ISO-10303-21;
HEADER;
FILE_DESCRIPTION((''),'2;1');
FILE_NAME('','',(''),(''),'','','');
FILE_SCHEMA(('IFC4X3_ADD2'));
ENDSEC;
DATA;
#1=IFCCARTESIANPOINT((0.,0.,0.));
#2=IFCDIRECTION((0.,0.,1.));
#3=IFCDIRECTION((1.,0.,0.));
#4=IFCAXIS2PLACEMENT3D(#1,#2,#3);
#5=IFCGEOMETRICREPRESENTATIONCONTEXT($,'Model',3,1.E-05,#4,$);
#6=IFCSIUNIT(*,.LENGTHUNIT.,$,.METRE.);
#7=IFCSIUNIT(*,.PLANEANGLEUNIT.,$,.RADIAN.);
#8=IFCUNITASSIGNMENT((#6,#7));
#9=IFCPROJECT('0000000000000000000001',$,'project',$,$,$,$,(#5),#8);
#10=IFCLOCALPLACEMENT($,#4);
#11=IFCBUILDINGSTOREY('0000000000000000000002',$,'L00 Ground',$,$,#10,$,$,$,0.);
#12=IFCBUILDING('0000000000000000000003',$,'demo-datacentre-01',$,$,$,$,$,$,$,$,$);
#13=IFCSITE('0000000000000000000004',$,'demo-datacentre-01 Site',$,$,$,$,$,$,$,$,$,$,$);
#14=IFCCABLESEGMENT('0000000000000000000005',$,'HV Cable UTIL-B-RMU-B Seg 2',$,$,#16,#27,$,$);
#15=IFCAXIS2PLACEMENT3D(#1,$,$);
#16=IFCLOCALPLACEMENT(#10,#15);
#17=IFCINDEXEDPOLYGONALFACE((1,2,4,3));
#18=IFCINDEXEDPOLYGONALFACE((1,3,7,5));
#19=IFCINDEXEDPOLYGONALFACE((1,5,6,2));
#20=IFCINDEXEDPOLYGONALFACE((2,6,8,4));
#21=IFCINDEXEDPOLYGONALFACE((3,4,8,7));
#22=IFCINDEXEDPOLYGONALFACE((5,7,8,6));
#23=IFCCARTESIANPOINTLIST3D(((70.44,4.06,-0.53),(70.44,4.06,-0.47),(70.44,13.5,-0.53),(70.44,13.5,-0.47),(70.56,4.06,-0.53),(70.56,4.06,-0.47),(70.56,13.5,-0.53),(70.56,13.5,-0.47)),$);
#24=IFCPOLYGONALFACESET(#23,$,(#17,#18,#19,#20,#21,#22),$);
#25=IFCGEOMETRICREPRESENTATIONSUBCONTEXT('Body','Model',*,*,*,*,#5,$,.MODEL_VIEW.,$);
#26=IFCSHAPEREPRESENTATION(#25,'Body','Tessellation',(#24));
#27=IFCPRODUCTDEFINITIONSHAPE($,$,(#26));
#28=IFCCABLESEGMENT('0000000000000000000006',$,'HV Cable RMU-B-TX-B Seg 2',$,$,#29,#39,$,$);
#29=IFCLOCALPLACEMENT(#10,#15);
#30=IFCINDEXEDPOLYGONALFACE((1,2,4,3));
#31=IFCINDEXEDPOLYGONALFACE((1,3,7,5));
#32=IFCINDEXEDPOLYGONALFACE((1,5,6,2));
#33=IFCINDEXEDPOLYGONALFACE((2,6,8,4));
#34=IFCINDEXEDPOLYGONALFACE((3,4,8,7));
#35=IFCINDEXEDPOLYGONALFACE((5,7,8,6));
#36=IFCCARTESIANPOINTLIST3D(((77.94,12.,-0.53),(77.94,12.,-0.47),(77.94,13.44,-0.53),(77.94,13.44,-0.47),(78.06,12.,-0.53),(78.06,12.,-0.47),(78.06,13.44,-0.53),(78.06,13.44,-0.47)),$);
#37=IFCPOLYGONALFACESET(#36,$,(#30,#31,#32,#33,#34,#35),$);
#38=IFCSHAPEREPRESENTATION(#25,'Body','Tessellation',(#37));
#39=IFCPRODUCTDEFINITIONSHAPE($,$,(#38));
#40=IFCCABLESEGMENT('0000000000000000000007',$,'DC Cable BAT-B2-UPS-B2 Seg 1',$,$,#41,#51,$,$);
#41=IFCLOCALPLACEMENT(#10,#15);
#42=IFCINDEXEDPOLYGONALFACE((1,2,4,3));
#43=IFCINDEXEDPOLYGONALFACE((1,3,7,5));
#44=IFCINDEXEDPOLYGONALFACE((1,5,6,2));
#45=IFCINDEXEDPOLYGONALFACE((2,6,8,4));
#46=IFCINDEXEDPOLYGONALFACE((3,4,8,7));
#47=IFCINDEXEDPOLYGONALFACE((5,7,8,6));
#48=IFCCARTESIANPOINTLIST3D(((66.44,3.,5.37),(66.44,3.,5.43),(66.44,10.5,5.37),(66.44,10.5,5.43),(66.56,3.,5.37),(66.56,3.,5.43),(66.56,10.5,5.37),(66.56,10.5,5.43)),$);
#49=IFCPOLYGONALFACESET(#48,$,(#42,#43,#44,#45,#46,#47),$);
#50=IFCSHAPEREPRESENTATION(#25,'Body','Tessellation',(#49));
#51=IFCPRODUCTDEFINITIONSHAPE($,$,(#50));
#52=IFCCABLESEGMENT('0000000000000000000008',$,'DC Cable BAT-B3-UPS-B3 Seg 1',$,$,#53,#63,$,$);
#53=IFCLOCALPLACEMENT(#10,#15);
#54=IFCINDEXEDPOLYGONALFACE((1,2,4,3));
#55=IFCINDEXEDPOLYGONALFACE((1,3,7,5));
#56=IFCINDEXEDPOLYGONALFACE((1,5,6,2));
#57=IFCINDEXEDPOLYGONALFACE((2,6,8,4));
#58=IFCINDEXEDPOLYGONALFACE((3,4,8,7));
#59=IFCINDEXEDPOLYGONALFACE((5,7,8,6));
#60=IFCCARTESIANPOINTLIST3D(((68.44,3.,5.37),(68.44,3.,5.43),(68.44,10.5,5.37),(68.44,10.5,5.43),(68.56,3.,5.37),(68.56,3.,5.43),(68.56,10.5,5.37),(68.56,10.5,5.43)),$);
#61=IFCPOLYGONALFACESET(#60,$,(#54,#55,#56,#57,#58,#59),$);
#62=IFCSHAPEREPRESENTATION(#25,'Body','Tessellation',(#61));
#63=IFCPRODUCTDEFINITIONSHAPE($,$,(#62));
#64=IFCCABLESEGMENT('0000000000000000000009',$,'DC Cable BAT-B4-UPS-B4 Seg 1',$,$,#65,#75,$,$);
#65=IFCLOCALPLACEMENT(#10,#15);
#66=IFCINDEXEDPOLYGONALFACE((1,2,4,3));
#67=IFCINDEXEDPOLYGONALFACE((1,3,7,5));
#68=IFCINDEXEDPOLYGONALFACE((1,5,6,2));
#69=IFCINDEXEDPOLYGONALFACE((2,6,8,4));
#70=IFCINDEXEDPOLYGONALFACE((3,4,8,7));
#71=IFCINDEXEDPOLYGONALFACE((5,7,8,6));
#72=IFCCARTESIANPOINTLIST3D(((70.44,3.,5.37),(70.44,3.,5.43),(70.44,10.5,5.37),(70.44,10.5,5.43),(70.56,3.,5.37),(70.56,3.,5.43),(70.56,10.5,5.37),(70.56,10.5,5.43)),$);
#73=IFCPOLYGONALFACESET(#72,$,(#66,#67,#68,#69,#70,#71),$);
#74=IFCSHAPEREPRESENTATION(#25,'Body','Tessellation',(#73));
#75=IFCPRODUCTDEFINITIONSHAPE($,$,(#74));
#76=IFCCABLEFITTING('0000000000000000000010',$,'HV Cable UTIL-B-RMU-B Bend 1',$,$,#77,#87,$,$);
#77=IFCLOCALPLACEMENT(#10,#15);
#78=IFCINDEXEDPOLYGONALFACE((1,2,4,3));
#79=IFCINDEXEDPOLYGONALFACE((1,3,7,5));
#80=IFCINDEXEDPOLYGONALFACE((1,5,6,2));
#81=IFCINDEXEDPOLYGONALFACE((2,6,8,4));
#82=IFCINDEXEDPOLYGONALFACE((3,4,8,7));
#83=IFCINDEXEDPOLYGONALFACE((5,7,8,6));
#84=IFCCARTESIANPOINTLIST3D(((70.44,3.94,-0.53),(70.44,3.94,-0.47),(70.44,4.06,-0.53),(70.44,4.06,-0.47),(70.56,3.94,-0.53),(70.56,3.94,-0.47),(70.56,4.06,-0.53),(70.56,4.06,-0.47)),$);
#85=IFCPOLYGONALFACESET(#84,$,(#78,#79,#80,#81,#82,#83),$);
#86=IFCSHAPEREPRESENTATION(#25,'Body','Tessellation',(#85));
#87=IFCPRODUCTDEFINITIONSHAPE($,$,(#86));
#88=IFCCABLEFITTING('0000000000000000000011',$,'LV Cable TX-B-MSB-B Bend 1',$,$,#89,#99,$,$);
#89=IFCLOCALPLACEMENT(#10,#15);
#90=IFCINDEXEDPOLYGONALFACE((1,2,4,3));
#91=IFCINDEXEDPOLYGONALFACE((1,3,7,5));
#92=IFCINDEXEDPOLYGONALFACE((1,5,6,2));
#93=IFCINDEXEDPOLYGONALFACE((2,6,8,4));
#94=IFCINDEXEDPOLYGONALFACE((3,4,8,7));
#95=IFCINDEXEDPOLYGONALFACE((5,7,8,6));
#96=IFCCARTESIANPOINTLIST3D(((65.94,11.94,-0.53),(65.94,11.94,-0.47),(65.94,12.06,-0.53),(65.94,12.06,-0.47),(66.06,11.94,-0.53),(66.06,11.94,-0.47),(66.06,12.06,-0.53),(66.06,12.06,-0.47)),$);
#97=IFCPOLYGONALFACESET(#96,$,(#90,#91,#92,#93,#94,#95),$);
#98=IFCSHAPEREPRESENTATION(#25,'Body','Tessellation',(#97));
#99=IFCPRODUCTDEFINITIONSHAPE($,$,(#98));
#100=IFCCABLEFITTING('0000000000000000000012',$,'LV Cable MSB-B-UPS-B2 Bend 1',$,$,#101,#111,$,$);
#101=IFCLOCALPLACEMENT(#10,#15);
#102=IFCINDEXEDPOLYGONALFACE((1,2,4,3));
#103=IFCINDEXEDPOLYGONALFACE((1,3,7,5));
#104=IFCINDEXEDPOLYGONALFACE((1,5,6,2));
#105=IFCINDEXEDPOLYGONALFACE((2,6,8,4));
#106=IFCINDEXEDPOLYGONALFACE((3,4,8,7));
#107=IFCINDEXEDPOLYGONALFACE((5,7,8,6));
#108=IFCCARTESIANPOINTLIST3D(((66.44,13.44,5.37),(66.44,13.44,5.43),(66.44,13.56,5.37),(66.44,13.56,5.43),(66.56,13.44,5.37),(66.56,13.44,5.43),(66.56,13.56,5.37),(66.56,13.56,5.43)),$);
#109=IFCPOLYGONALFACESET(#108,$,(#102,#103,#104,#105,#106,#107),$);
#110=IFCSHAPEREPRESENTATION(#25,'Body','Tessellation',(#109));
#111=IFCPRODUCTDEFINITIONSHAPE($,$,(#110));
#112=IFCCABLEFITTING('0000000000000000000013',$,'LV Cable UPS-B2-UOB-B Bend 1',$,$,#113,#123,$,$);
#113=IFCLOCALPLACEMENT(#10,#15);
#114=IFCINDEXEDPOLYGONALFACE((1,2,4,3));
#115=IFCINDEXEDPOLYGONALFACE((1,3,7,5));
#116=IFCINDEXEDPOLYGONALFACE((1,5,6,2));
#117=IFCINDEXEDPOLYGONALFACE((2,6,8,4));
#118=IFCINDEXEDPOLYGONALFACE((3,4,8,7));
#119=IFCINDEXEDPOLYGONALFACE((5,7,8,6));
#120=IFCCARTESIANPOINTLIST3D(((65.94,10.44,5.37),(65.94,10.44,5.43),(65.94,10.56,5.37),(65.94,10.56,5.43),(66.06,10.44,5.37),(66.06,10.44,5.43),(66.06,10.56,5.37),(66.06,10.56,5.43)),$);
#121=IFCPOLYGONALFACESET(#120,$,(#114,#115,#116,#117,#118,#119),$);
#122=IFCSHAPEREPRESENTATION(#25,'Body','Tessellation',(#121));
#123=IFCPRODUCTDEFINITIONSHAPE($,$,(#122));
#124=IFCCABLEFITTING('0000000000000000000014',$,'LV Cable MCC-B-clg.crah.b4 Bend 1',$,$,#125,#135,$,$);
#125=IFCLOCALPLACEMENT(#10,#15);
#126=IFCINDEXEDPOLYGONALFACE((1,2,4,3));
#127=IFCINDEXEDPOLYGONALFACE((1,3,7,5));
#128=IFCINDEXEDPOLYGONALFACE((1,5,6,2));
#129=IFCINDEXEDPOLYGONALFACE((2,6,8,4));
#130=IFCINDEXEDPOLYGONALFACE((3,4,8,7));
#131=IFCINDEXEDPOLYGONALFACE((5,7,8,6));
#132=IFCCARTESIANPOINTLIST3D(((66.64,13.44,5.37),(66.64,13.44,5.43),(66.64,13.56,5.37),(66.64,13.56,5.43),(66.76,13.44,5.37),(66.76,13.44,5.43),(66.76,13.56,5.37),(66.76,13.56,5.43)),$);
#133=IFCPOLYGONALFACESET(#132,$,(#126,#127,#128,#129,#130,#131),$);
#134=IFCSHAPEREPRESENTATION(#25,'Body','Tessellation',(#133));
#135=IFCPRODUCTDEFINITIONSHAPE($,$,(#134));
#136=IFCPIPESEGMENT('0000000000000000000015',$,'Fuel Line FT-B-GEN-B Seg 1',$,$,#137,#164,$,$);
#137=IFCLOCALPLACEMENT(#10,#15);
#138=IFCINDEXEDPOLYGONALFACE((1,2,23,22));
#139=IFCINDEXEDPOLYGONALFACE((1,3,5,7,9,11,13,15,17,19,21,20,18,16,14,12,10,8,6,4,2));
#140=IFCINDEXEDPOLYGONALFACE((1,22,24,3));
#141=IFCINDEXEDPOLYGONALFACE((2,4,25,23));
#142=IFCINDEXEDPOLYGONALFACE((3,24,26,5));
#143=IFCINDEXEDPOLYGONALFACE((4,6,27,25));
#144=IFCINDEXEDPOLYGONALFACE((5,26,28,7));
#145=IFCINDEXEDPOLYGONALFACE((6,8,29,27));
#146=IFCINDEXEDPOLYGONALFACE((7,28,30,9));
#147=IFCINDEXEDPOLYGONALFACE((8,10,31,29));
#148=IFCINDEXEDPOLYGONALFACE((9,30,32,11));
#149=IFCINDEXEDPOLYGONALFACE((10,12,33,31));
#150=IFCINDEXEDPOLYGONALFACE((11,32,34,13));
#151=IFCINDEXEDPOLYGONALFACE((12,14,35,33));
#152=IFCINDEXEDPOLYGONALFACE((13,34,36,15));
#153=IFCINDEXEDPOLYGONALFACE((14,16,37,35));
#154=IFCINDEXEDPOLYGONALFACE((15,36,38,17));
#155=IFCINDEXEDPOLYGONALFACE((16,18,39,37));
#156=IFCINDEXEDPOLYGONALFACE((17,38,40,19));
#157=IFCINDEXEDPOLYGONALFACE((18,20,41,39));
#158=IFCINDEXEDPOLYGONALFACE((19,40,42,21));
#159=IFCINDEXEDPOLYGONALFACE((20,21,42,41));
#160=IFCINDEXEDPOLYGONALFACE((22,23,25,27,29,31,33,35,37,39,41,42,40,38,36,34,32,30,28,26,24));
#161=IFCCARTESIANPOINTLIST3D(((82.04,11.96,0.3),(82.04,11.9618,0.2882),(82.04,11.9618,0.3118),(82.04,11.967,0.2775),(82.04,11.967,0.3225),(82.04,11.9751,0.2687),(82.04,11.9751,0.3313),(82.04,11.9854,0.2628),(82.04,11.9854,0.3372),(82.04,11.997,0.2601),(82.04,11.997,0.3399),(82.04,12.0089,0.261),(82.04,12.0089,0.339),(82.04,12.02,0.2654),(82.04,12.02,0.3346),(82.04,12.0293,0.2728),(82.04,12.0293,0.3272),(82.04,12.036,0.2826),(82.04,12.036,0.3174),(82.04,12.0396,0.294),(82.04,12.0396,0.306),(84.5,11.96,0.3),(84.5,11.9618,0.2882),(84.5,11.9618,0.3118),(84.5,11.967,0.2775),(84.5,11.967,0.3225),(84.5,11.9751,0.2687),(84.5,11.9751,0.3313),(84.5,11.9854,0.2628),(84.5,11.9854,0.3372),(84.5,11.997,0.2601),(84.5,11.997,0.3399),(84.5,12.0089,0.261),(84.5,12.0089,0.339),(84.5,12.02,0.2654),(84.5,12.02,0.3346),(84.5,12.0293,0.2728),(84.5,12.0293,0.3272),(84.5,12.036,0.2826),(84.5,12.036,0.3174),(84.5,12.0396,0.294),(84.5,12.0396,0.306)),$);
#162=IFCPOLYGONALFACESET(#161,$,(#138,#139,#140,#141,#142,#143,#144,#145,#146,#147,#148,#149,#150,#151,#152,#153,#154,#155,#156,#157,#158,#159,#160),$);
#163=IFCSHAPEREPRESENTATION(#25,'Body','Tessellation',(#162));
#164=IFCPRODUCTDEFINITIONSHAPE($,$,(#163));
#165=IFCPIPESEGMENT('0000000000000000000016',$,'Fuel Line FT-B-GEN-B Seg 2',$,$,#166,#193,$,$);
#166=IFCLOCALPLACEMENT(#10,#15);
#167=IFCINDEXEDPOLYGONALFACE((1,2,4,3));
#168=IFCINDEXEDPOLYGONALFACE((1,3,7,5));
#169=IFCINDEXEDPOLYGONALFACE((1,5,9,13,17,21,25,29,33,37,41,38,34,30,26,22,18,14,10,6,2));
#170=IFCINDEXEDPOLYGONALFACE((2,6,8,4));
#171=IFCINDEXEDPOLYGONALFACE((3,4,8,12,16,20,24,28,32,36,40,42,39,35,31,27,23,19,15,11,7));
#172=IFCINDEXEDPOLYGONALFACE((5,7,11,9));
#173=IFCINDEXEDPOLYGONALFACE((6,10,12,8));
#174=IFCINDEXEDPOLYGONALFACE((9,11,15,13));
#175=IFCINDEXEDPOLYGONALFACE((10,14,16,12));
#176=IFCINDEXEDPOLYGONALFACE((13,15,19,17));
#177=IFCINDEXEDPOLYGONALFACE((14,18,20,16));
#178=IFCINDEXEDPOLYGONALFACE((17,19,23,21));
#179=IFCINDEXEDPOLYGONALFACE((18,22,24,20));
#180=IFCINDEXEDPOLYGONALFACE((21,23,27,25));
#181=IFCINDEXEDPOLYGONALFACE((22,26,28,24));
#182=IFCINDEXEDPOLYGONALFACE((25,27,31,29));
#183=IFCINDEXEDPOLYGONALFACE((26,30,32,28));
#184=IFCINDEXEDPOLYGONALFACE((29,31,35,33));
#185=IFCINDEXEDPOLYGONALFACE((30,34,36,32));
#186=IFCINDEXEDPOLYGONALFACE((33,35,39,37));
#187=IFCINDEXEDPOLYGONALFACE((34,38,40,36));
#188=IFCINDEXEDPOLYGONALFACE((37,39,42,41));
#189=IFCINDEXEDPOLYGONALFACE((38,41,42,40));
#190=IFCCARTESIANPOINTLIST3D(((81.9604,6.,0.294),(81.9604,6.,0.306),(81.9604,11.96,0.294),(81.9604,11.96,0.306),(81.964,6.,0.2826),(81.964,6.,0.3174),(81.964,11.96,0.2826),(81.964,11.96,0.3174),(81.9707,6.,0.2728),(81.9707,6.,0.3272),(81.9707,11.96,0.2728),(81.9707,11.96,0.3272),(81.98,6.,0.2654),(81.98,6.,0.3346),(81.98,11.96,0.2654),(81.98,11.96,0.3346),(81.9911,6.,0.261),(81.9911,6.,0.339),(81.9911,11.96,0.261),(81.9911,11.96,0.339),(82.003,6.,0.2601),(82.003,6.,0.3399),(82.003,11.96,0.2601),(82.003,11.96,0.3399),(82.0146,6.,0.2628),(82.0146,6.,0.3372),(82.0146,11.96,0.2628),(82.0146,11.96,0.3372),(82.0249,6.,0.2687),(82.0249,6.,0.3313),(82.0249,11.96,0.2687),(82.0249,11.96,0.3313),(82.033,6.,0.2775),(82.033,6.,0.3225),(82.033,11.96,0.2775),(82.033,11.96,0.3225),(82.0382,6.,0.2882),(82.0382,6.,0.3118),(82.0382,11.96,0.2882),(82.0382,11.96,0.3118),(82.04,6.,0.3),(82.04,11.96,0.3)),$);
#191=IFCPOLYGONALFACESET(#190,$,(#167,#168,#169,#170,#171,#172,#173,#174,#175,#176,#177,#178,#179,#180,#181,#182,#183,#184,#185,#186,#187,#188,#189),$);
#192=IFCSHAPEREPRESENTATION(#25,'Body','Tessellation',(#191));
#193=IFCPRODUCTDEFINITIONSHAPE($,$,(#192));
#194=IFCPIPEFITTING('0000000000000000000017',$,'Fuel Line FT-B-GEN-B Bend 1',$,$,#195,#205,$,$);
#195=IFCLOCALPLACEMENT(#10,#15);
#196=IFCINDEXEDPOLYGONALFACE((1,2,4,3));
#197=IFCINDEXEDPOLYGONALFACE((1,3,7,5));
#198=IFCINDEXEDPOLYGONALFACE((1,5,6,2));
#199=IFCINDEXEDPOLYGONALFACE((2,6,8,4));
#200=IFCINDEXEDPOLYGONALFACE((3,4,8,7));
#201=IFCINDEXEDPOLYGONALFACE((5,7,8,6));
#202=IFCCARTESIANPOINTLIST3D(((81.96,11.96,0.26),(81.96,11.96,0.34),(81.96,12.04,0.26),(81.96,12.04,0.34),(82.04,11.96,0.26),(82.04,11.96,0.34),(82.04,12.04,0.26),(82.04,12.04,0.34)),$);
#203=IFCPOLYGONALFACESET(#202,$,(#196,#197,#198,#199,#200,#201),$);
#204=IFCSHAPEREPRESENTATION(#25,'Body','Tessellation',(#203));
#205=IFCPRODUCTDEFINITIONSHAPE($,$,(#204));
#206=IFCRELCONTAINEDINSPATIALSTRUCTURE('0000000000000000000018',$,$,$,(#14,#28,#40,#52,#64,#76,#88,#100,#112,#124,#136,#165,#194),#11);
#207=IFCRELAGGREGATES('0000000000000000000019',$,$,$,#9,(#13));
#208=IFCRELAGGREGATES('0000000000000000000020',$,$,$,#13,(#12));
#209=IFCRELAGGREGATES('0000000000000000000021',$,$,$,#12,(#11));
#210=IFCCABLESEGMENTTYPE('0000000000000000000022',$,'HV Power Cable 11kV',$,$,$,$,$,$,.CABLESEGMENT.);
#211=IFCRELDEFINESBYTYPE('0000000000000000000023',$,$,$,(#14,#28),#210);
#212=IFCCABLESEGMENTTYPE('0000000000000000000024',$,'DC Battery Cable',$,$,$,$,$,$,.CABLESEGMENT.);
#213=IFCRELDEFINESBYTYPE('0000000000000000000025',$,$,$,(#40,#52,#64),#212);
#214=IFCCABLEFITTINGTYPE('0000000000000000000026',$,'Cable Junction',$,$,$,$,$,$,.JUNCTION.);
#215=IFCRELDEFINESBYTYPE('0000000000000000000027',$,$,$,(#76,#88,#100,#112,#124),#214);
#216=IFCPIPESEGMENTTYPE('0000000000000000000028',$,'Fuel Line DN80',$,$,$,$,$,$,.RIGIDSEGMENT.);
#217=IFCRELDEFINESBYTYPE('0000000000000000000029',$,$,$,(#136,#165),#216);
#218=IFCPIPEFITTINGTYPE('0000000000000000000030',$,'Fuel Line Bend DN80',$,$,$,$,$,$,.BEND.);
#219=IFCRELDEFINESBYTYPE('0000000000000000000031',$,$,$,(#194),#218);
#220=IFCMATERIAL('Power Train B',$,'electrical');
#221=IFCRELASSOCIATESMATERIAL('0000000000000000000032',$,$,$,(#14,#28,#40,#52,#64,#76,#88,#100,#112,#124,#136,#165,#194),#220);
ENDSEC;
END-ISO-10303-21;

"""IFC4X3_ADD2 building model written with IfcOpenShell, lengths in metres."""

from ifc_helpers import new_model, si_unit, frame, origin_with_axes, place, context, subcontext, project, spatial, rectangle, circle, extrude, material, type_object, element, save


model = new_model("IFC4X3_ADD2")

# Units and contexts
model_context = context("Model", 3, precision=1e-05, world=origin_with_axes())
body_context = subcontext(model_context, "Body", "Model", "MODEL_VIEW")
ifc_project = project(units=[si_unit("LENGTHUNIT", "METRE"), si_unit("PLANEANGLEUNIT", "RADIAN")], contexts=[model_context])

# Site, building, storey
site = spatial("IfcSite", under=ifc_project, Name="demo-datacentre-01 Site")
building = spatial("IfcBuilding", under=site, Name="demo-datacentre-01")
storey_placement = place(None, origin_with_axes())
storey = spatial("IfcBuildingStorey", under=building, at=storey_placement, Name="L00 Ground", Elevation=0.0)

# Shared definitions
ifc_material = material(Name="Power Train B", Category="electrical")

# Cable segments
cable_segment_type_1 = type_object("IfcCableSegmentType", Name="HV Power Cable 11kV", PredefinedType="CABLESEGMENT")
cable_segment_1_placement = place(storey_placement, frame((70.5, 4.06, -0.5), z_axis=(0.0, 1.0, 0.0), x_axis=(-1.0, 0.0, 0.0)))
element("IfcCableSegment", 1, at=cable_segment_1_placement, inside=storey, type_object=cable_segment_type_1, material=ifc_material, Name="HV Cable UTIL-B-RMU-B Seg 2", context=body_context, shape_type="SweptSolid", body=[
    extrude(rectangle(XDim=0.12, YDim=0.06), origin_with_axes(), (0.0, 0.0, 1.0), 9.44),
])
cable_segment_2_placement = place(storey_placement, frame((78.0, 13.44, -0.5), z_axis=(0.0, -1.0, 0.0), x_axis=(1.0, 0.0, 0.0)))
element("IfcCableSegment", 2, at=cable_segment_2_placement, inside=storey, type_object=cable_segment_type_1, material=ifc_material, Name="HV Cable RMU-B-TX-B Seg 2", context=body_context, shape_type="SweptSolid", body=[
    extrude(rectangle(XDim=0.12, YDim=0.06), origin_with_axes(), (0.0, 0.0, 1.0), 1.44),
])
cable_segment_type_2 = type_object("IfcCableSegmentType", Name="DC Battery Cable", PredefinedType="CABLESEGMENT")
for number, where, z_axis, x_axis, name in (
    (3, (66.5, 3.0, 5.4), (0.0, 1.0, 0.0), (-1.0, 0.0, 0.0), "DC Cable BAT-B2-UPS-B2 Seg 1"),
    (4, (68.5, 3.0, 5.4), (0.0, 1.0, 0.0), (-1.0, 0.0, 0.0), "DC Cable BAT-B3-UPS-B3 Seg 1"),
    (5, (70.5, 3.0, 5.4), (0.0, 1.0, 0.0), (-1.0, 0.0, 0.0), "DC Cable BAT-B4-UPS-B4 Seg 1"),
):
    element("IfcCableSegment", number, at=place(storey_placement, frame(where, z_axis=z_axis, x_axis=x_axis)), inside=storey, type_object=cable_segment_type_2, material=ifc_material, Name=name, context=body_context, shape_type="SweptSolid", body=[
        extrude(rectangle(XDim=0.12, YDim=0.06), origin_with_axes(), (0.0, 0.0, 1.0), 7.5),
    ])

# Cable fittings
cable_fitting_type = type_object("IfcCableFittingType", Name="Cable Junction", PredefinedType="JUNCTION")
for number, where, z_axis, x_axis, name in (
    (6, (70.5, 4.0, -0.53), (0.0, 0.0, 1.0), (1.0, 0.0, 0.0), "HV Cable UTIL-B-RMU-B Bend 1"),
    (7, (66.0, 12.0, -0.53), (0.0, 0.0, 1.0), (1.0, 0.0, 0.0), "LV Cable TX-B-MSB-B Bend 1"),
    (8, (66.5, 13.5, 5.37), (0.0, 0.0, 1.0), (1.0, 0.0, 0.0), "LV Cable MSB-B-UPS-B2 Bend 1"),
    (9, (66.0, 10.5, 5.37), (0.0, 0.0, 1.0), (1.0, 0.0, 0.0), "LV Cable UPS-B2-UOB-B Bend 1"),
    (10, (66.7, 13.5, 5.37), (0.0, 0.0, 1.0), (1.0, 0.0, 0.0), "LV Cable MCC-B-clg.crah.b4 Bend 1"),
):
    element("IfcCableFitting", number, at=place(storey_placement, frame(where, z_axis=z_axis, x_axis=x_axis)), inside=storey, type_object=cable_fitting_type, material=ifc_material, Name=name, context=body_context, shape_type="SweptSolid", body=[
        extrude(rectangle(XDim=0.12, YDim=0.12), origin_with_axes(), (0.0, 0.0, 1.0), 0.06),
    ])

# Pipe segments
pipe_segment_type = type_object("IfcPipeSegmentType", Name="Fuel Line DN80", PredefinedType="RIGIDSEGMENT")
pipe_segment_1_placement = place(storey_placement, frame((84.5, 12.0, 0.3), z_axis=(-1.0, 0.0, 0.0), x_axis=(0.0, -1.0, 0.0)))
element("IfcPipeSegment", 11, at=pipe_segment_1_placement, inside=storey, type_object=pipe_segment_type, material=ifc_material, Name="Fuel Line FT-B-GEN-B Seg 1", context=body_context, shape_type="SweptSolid", body=[
    extrude(circle(Radius=0.04), origin_with_axes(), (0.0, 0.0, 1.0), 2.46),
])
pipe_segment_2_placement = place(storey_placement, frame((82.0, 11.96, 0.3), z_axis=(0.0, -1.0, 0.0), x_axis=(1.0, 0.0, 0.0)))
element("IfcPipeSegment", 12, at=pipe_segment_2_placement, inside=storey, type_object=pipe_segment_type, material=ifc_material, Name="Fuel Line FT-B-GEN-B Seg 2", context=body_context, shape_type="SweptSolid", body=[
    extrude(circle(Radius=0.04), origin_with_axes(), (0.0, 0.0, 1.0), 5.96),
])

# Pipe fitting
pipe_fitting_type = type_object("IfcPipeFittingType", Name="Fuel Line Bend DN80", PredefinedType="BEND")
pipe_fitting_placement = place(storey_placement, frame((82.0, 12.0, 0.26), z_axis=(0.0, 0.0, 1.0), x_axis=(1.0, 0.0, 0.0)))
element("IfcPipeFitting", 13, at=pipe_fitting_placement, inside=storey, type_object=pipe_fitting_type, material=ifc_material, Name="Fuel Line FT-B-GEN-B Bend 1", context=body_context, shape_type="SweptSolid", body=[
    extrude(rectangle(XDim=0.08, YDim=0.08), origin_with_axes(), (0.0, 0.0, 1.0), 0.08),
])

save(model, "model.ifc")
